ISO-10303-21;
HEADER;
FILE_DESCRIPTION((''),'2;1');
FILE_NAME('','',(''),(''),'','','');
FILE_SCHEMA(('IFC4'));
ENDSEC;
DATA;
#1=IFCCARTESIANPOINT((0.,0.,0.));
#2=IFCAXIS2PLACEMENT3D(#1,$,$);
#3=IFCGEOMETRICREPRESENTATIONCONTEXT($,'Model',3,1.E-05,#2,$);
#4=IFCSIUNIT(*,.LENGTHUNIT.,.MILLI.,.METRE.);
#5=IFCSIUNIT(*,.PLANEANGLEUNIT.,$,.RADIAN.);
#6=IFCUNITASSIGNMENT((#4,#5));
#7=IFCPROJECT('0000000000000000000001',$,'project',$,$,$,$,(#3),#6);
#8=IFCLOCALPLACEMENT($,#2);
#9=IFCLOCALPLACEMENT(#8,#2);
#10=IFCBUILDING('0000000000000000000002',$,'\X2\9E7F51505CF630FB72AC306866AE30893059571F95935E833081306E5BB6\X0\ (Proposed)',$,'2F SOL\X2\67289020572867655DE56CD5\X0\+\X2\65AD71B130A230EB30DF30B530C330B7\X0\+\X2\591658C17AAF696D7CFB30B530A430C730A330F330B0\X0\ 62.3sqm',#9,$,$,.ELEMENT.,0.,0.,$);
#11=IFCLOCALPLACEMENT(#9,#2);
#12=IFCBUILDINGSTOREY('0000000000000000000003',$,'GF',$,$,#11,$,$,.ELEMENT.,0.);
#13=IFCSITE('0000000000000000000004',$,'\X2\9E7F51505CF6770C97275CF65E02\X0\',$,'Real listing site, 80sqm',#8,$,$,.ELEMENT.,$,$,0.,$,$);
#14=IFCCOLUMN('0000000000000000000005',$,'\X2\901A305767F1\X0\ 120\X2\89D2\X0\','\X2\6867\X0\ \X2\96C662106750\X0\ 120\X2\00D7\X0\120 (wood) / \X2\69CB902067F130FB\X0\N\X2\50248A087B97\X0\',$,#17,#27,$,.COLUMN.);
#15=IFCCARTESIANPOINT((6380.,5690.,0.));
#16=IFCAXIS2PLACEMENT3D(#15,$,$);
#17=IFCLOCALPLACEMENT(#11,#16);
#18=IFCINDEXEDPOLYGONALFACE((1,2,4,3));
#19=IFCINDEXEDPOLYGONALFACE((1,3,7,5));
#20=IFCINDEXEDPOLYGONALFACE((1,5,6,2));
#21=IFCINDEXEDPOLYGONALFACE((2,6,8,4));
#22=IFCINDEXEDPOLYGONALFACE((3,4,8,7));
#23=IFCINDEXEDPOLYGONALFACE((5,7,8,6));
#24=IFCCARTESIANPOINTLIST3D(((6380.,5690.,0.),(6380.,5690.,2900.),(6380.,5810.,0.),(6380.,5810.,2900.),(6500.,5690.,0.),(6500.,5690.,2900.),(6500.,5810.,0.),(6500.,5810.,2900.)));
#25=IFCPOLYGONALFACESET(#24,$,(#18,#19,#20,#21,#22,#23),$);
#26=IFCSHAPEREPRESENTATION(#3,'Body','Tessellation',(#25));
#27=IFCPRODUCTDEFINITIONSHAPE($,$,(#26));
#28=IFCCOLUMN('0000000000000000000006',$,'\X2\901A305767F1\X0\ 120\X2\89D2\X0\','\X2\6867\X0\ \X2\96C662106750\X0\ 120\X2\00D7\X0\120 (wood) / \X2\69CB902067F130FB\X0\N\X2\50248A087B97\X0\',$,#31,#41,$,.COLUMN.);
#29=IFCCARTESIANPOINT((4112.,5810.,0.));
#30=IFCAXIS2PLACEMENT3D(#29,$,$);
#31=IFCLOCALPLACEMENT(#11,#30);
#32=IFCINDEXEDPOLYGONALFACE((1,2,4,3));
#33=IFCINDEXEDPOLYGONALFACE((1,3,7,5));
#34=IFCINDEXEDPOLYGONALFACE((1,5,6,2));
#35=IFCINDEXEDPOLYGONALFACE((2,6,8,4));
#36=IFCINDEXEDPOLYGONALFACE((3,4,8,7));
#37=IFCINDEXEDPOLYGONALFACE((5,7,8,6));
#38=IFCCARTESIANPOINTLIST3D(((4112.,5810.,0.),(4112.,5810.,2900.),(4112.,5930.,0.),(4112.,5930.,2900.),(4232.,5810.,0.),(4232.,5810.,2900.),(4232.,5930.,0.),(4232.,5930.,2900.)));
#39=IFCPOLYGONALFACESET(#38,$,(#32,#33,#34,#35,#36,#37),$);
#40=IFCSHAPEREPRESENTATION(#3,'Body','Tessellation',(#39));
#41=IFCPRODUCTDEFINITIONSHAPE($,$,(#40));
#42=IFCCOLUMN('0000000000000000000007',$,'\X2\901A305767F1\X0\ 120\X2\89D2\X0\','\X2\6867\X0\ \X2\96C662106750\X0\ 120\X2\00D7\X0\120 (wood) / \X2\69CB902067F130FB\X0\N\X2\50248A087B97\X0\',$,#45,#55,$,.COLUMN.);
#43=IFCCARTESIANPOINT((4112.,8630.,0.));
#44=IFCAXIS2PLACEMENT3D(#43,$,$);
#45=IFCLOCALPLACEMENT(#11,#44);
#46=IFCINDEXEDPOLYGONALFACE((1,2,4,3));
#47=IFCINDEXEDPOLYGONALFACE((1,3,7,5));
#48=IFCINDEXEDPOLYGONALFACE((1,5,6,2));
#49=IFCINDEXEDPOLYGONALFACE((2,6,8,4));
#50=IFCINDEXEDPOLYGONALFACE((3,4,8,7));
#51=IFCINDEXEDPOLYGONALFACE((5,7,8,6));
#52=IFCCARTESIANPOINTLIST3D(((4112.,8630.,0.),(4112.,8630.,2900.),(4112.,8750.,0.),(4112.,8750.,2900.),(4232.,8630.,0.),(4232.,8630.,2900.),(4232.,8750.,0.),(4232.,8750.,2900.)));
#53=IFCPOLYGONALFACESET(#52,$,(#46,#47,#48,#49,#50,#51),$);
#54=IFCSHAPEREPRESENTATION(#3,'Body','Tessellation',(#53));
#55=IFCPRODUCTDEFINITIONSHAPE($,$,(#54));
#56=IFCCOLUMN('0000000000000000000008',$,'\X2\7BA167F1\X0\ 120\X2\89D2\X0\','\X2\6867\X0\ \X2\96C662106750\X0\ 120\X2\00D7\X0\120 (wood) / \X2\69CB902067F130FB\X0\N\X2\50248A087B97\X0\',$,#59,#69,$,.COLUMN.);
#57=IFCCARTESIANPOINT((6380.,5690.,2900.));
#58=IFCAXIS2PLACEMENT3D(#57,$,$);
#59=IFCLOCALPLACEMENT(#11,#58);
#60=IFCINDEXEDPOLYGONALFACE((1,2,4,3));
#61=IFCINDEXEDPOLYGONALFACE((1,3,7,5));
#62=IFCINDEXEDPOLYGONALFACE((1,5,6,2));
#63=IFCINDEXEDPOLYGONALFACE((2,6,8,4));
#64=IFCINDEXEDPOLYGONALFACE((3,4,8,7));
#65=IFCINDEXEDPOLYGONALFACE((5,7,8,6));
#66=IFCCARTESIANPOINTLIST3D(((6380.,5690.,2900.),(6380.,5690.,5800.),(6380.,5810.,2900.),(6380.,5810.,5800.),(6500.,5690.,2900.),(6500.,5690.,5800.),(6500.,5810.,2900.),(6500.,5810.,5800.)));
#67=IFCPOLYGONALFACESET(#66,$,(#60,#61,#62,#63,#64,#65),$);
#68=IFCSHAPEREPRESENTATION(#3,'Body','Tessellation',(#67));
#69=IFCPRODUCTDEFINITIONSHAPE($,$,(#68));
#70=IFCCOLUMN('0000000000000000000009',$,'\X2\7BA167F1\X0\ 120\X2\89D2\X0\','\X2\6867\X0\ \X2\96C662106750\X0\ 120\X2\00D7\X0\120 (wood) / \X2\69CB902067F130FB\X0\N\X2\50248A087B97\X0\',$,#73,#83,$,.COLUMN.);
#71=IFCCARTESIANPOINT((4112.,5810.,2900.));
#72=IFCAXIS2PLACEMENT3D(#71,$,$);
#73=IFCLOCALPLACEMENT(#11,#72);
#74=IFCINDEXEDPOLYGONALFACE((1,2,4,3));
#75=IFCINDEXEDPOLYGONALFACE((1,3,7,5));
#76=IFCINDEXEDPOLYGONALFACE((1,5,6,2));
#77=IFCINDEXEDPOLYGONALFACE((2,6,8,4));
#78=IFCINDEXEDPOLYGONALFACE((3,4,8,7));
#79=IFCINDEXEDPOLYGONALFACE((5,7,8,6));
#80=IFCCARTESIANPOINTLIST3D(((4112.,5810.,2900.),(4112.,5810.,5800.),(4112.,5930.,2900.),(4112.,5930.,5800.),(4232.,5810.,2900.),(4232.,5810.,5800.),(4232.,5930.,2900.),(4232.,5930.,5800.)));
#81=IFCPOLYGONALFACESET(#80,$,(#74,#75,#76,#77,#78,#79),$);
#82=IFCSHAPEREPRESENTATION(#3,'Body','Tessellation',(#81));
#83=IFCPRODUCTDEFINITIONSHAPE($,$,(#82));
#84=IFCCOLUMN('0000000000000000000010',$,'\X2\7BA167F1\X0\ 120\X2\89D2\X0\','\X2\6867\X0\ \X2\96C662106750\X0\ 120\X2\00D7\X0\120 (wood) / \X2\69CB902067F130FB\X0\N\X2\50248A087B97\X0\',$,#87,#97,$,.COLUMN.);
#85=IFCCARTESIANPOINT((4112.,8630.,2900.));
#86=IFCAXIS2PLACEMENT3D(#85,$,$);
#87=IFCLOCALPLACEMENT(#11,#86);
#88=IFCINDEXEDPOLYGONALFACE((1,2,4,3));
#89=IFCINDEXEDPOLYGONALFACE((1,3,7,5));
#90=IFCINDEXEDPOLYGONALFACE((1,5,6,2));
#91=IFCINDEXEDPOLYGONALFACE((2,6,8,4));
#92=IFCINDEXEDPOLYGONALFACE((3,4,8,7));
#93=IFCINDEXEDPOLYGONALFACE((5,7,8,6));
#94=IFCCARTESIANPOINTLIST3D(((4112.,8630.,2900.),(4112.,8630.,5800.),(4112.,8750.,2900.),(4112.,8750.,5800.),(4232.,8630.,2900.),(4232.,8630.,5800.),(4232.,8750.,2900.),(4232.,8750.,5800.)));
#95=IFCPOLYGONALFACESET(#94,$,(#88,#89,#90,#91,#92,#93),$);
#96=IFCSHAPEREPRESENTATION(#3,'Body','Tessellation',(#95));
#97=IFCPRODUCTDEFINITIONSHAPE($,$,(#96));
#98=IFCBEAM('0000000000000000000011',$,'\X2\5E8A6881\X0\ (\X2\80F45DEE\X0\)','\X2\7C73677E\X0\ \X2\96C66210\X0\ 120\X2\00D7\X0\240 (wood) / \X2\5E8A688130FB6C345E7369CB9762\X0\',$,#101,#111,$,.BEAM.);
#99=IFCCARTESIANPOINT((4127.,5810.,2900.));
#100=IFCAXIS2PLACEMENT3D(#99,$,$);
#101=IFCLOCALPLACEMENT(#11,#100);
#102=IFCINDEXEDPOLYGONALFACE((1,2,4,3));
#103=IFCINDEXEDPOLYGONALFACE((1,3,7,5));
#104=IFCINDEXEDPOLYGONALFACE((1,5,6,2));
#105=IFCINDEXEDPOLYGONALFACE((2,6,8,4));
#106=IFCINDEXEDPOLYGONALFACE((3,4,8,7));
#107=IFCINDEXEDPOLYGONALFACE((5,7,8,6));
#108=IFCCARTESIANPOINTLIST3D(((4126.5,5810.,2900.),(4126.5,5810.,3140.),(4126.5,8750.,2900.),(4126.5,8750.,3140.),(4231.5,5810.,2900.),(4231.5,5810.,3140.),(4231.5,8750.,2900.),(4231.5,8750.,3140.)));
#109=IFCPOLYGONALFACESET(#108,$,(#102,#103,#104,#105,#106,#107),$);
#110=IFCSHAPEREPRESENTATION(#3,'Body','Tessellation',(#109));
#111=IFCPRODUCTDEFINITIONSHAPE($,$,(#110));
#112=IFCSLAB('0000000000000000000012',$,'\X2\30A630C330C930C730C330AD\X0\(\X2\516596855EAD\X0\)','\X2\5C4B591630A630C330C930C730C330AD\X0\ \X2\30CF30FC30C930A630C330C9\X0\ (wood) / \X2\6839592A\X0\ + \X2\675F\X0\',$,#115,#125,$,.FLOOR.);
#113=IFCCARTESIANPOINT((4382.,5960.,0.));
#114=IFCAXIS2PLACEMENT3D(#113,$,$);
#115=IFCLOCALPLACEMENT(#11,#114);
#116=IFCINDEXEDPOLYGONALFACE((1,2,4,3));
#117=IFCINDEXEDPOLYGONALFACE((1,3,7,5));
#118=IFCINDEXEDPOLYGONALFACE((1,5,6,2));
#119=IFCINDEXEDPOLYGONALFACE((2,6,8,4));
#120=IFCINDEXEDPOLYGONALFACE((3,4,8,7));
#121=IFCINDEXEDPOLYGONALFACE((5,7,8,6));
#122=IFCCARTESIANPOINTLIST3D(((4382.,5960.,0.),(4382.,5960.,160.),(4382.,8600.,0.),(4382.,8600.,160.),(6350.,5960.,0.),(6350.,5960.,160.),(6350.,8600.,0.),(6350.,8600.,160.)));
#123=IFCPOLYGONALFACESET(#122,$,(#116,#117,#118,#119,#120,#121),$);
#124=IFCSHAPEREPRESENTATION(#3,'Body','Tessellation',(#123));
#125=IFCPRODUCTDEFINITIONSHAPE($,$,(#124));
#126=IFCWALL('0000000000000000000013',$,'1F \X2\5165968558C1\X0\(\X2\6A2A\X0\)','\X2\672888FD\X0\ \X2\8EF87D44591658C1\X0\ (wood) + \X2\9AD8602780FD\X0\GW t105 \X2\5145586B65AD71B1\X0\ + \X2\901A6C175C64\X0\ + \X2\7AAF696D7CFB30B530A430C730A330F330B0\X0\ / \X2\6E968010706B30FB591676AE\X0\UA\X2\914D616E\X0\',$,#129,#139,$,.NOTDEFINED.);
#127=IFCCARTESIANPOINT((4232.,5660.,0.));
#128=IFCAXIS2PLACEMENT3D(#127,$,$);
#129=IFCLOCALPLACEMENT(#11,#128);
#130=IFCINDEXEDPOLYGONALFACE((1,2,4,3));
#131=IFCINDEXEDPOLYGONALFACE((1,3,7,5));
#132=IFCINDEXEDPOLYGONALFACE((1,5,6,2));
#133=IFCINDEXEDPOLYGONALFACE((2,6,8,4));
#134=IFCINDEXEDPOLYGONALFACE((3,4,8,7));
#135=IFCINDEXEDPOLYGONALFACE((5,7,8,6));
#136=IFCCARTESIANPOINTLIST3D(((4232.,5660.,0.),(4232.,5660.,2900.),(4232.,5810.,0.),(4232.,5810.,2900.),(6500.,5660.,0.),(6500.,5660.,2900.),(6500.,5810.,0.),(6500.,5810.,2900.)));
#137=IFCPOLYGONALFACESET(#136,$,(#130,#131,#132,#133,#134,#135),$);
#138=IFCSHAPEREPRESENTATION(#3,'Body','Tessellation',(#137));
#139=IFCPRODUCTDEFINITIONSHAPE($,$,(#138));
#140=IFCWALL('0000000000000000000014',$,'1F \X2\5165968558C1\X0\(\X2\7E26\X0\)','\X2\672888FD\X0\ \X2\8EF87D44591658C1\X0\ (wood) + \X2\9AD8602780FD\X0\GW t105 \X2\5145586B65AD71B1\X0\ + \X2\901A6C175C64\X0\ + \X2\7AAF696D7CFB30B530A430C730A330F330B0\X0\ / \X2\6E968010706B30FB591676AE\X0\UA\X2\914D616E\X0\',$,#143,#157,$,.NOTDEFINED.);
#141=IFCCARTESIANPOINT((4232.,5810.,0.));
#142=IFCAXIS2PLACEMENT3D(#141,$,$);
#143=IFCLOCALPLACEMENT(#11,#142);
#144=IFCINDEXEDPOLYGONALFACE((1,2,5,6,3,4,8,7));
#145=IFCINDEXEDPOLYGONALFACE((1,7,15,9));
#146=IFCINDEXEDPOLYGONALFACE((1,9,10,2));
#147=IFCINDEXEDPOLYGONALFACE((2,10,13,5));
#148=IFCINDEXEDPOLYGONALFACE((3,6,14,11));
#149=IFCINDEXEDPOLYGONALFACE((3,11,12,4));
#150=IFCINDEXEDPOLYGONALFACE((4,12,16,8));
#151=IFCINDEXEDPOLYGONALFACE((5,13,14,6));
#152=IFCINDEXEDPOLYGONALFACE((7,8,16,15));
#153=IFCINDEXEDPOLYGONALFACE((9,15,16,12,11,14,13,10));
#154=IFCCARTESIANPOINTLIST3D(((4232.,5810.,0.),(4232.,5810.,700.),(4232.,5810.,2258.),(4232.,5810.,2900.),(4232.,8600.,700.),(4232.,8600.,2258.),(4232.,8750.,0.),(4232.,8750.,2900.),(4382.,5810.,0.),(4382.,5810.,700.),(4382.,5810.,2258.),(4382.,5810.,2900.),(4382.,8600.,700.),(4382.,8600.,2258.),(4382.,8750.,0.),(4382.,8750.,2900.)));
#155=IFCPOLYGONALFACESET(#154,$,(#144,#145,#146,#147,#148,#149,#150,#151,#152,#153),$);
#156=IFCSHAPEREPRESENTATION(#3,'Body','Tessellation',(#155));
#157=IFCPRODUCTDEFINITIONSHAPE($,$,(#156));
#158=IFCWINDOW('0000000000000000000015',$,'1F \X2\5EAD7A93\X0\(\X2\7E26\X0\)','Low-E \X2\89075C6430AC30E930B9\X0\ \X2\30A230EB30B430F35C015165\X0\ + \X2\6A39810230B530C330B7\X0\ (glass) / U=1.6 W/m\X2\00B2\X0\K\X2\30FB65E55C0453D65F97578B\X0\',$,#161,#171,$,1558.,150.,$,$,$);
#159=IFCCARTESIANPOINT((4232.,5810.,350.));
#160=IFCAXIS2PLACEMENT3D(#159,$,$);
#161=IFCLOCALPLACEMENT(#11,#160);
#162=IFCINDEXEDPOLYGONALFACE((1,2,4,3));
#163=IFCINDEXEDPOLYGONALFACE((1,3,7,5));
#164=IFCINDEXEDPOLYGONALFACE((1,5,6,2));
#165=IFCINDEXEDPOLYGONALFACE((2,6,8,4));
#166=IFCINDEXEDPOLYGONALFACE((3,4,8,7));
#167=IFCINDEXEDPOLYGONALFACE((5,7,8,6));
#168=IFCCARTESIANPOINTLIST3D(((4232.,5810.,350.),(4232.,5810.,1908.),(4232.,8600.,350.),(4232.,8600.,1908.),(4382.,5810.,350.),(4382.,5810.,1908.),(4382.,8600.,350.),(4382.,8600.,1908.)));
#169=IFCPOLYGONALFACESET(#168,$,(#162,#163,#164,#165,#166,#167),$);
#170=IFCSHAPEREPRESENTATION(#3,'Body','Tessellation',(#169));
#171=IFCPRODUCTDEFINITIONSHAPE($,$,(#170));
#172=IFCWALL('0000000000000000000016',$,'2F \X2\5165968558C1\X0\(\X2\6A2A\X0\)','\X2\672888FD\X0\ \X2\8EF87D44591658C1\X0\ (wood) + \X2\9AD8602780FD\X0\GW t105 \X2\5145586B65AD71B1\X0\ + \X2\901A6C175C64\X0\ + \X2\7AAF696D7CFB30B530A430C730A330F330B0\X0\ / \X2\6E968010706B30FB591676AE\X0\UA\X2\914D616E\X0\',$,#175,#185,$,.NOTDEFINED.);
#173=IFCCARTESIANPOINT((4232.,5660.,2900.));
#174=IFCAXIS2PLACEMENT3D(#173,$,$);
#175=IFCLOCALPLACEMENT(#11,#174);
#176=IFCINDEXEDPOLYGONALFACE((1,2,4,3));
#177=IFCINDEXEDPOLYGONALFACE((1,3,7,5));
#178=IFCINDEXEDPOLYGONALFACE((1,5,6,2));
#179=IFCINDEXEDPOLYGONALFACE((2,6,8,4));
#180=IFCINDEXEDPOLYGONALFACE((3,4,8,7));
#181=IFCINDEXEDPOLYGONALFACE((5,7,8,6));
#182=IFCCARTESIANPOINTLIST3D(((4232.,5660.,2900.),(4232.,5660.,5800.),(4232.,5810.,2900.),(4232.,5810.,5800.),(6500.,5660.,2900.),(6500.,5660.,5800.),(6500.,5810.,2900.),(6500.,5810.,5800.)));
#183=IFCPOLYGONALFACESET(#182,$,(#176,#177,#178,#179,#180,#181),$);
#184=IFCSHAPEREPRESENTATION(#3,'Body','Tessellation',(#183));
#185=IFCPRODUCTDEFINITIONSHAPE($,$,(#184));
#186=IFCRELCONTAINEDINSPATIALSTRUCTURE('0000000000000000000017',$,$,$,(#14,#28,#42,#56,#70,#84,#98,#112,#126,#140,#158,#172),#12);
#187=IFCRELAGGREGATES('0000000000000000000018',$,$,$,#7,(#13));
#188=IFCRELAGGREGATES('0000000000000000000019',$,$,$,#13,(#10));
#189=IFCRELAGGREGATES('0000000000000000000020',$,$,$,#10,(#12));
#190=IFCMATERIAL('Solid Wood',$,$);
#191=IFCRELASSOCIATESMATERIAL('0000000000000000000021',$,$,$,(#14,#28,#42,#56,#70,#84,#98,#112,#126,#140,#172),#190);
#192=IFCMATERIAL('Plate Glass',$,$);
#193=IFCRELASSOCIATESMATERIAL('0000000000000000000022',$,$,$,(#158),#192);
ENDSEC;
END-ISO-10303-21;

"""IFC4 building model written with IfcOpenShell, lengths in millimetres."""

from ifc_helpers import new_model, si_unit, frame, frame_2d, origin, place, context, project, spatial, rectangle, extrude, material, element, fill, save


model = new_model("IFC4")

# Units and contexts
model_context = context("Model", 3, precision=1e-05, world=origin())
ifc_project = project(units=[si_unit("LENGTHUNIT", "METRE", prefix="MILLI"), si_unit("PLANEANGLEUNIT", "RADIAN")], contexts=[model_context])

# Site, building, storey
site_placement = place(None, origin())
site = spatial("IfcSite", under=ifc_project, at=site_placement, Name="鹿児島県霧島市", ObjectType="Real listing site, 80sqm", CompositionType="ELEMENT", RefElevation=0.0)
building_placement = place(site_placement, origin())
building = spatial("IfcBuilding", under=site, at=building_placement, Name="鹿児島・犬と暮らす土間広めの家 (Proposed)", ObjectType="2F SOL木造在来工法+断熱アルミサッシ+外壁窯業系サイディング 62.3sqm", CompositionType="ELEMENT", ElevationOfRefHeight=0.0, ElevationOfTerrain=0.0)
storey_placement = place(building_placement, origin())
storey = spatial("IfcBuildingStorey", under=building, at=storey_placement, Name="GF", CompositionType="ELEMENT", Elevation=0.0)

# Columns
ifc_material_1 = material(Name="Solid Wood")
column_1_placement = place(storey_placement, frame((6380.0, 5690.0, 0.0)))
element("IfcColumn", 1, at=column_1_placement, inside=storey, material=ifc_material_1, Name="通し柱 120角", Description="桧 集成材 120×120 (wood) / 構造柱・N値計算", PredefinedType="COLUMN", context=model_context, shape_type="SweptSolid", body=[
    extrude(rectangle(XDim=120.0, YDim=120.0, at=frame_2d((60.0, 60.0))), frame((6380.0, 5690.0, 0.0)), (0.0, 0.0, 1.0), 2900.0),
])
column_2_placement = place(storey_placement, frame((4112.0, 5810.0, 0.0)))
element("IfcColumn", 2, at=column_2_placement, inside=storey, material=ifc_material_1, Name="通し柱 120角", Description="桧 集成材 120×120 (wood) / 構造柱・N値計算", PredefinedType="COLUMN", context=model_context, shape_type="SweptSolid", body=[
    extrude(rectangle(XDim=120.0, YDim=120.0, at=frame_2d((60.0, 60.0))), frame((4112.0, 5810.0, 0.0)), (0.0, 0.0, 1.0), 2900.0),
])
column_3_placement = place(storey_placement, frame((4112.0, 8630.0, 0.0)))
element("IfcColumn", 3, at=column_3_placement, inside=storey, material=ifc_material_1, Name="通し柱 120角", Description="桧 集成材 120×120 (wood) / 構造柱・N値計算", PredefinedType="COLUMN", context=model_context, shape_type="SweptSolid", body=[
    extrude(rectangle(XDim=120.0, YDim=120.0, at=frame_2d((60.0, 60.0))), frame((4112.0, 8630.0, 0.0)), (0.0, 0.0, 1.0), 2900.0),
])
column_4_placement = place(storey_placement, frame((6380.0, 5690.0, 2900.0)))
element("IfcColumn", 4, at=column_4_placement, inside=storey, material=ifc_material_1, Name="管柱 120角", Description="桧 集成材 120×120 (wood) / 構造柱・N値計算", PredefinedType="COLUMN", context=model_context, shape_type="SweptSolid", body=[
    extrude(rectangle(XDim=120.0, YDim=120.0, at=frame_2d((60.0, 60.0))), frame((6380.0, 5690.0, 2900.0)), (0.0, 0.0, 1.0), 2900.0),
])
column_5_placement = place(storey_placement, frame((4112.0, 5810.0, 2900.0)))
element("IfcColumn", 5, at=column_5_placement, inside=storey, material=ifc_material_1, Name="管柱 120角", Description="桧 集成材 120×120 (wood) / 構造柱・N値計算", PredefinedType="COLUMN", context=model_context, shape_type="SweptSolid", body=[
    extrude(rectangle(XDim=120.0, YDim=120.0, at=frame_2d((60.0, 60.0))), frame((4112.0, 5810.0, 2900.0)), (0.0, 0.0, 1.0), 2900.0),
])
column_6_placement = place(storey_placement, frame((4112.0, 8630.0, 2900.0)))
element("IfcColumn", 6, at=column_6_placement, inside=storey, material=ifc_material_1, Name="管柱 120角", Description="桧 集成材 120×120 (wood) / 構造柱・N値計算", PredefinedType="COLUMN", context=model_context, shape_type="SweptSolid", body=[
    extrude(rectangle(XDim=120.0, YDim=120.0, at=frame_2d((60.0, 60.0))), frame((4112.0, 8630.0, 2900.0)), (0.0, 0.0, 1.0), 2900.0),
])

# Beam
beam_1_placement = place(storey_placement, frame((4127.0, 5810.0, 2900.0)))
element("IfcBeam", 7, at=beam_1_placement, inside=storey, material=ifc_material_1, Name="床梁 (胴差)", Description="米松 集成 120×240 (wood) / 床梁・水平構面", PredefinedType="BEAM", context=model_context, shape_type="SweptSolid", body=[
    extrude(rectangle(XDim=105.0, YDim=2940.0, at=frame_2d((52.0, 1470.0))), frame((4127.0, 5810.0, 2900.0)), (0.0, 0.0, 1.0), 240.0),
])

# Slab
slab_placement = place(storey_placement, frame((4382.0, 5960.0, 0.0)))
element("IfcSlab", 8, at=slab_placement, inside=storey, material=ifc_material_1, Name="ウッドデッキ(入隅庭)", Description="屋外ウッドデッキ ハードウッド (wood) / 根太 + 束", PredefinedType="FLOOR", context=model_context, shape_type="SweptSolid", body=[
    extrude(rectangle(XDim=1968.0, YDim=2640.0, at=frame_2d((984.0, 1320.0))), frame((4382.0, 5960.0, 0.0)), (0.0, 0.0, 1.0), 160.0),
])

# Wall
wall_1_placement = place(storey_placement, frame((4232.0, 5660.0, 0.0)))
element("IfcWall", 9, at=wall_1_placement, inside=storey, material=ifc_material_1, Name="1F 入隅壁(横)", Description="木製 軸組外壁 (wood) + 高性能GW t105 充填断熱 + 通気層 + 窯業系サイディング / 準耐火・外皮UA配慮", PredefinedType="NOTDEFINED", context=model_context, shape_type="SweptSolid", body=[
    extrude(rectangle(XDim=2268.0, YDim=150.0, at=frame_2d((1134.0, 75.0))), frame((4232.0, 5660.0, 0.0)), (0.0, 0.0, 1.0), 2900.0),
])

# Wall, opening, window
wall_2_placement = place(storey_placement, frame((4232.0, 5810.0, 0.0)))
wall_2 = element("IfcWall", 10, at=wall_2_placement, inside=storey, material=ifc_material_1, Name="1F 入隅壁(縦)", Description="木製 軸組外壁 (wood) + 高性能GW t105 充填断熱 + 通気層 + 窯業系サイディング / 準耐火・外皮UA配慮", PredefinedType="NOTDEFINED", context=model_context, shape_type="SweptSolid", body=[
    extrude(rectangle(XDim=150.0, YDim=2940.0, at=frame_2d((75.0, 1470.0))), frame((4232.0, 5810.0, 0.0)), (0.0, 0.0, 1.0), 2900.0),
])
opening_1_placement = place(storey_placement, frame((4232.0, 5810.0, 350.0)))
opening_1 = element("IfcOpeningElement", 11, at=opening_1_placement, cuts=wall_2, PredefinedType="NOTDEFINED", context=model_context, shape_type="SweptSolid", body=[
    extrude(rectangle(XDim=150.0, YDim=2790.0, at=frame_2d((75.0, 1395.0))), frame((4232.0, 5810.0, 350.0)), (0.0, 0.0, 1.0), 1558.0),
])
ifc_material_2 = material(Name="Plate Glass")
window_1_placement = place(storey_placement, frame((4232.0, 5810.0, 350.0)))
window_1 = element("IfcWindow", 12, at=window_1_placement, inside=storey, material=ifc_material_2, Name="1F 庭窓(縦)", Description="Low-E 複層ガラス アルゴン封入 + 樹脂サッシ (glass) / U=1.6 W/m²K・日射取得型", OverallHeight=1558.0, OverallWidth=150.0, context=model_context, shape_type="SweptSolid", body=[
    extrude(rectangle(XDim=150.0, YDim=2790.0, at=frame_2d((75.0, 1395.0))), frame((4232.0, 5810.0, 350.0)), (0.0, 0.0, 1.0), 1558.0),
])
fill(opening_1, window_1)

# Wall
wall_3_placement = place(storey_placement, frame((4232.0, 5660.0, 2900.0)))
element("IfcWall", 13, at=wall_3_placement, inside=storey, material=ifc_material_1, Name="2F 入隅壁(横)", Description="木製 軸組外壁 (wood) + 高性能GW t105 充填断熱 + 通気層 + 窯業系サイディング / 準耐火・外皮UA配慮", PredefinedType="NOTDEFINED", context=model_context, shape_type="SweptSolid", body=[
    extrude(rectangle(XDim=2268.0, YDim=150.0, at=frame_2d((1134.0, 75.0))), frame((4232.0, 5660.0, 2900.0)), (0.0, 0.0, 1.0), 2900.0),
])

save(model, "model.ifc")
